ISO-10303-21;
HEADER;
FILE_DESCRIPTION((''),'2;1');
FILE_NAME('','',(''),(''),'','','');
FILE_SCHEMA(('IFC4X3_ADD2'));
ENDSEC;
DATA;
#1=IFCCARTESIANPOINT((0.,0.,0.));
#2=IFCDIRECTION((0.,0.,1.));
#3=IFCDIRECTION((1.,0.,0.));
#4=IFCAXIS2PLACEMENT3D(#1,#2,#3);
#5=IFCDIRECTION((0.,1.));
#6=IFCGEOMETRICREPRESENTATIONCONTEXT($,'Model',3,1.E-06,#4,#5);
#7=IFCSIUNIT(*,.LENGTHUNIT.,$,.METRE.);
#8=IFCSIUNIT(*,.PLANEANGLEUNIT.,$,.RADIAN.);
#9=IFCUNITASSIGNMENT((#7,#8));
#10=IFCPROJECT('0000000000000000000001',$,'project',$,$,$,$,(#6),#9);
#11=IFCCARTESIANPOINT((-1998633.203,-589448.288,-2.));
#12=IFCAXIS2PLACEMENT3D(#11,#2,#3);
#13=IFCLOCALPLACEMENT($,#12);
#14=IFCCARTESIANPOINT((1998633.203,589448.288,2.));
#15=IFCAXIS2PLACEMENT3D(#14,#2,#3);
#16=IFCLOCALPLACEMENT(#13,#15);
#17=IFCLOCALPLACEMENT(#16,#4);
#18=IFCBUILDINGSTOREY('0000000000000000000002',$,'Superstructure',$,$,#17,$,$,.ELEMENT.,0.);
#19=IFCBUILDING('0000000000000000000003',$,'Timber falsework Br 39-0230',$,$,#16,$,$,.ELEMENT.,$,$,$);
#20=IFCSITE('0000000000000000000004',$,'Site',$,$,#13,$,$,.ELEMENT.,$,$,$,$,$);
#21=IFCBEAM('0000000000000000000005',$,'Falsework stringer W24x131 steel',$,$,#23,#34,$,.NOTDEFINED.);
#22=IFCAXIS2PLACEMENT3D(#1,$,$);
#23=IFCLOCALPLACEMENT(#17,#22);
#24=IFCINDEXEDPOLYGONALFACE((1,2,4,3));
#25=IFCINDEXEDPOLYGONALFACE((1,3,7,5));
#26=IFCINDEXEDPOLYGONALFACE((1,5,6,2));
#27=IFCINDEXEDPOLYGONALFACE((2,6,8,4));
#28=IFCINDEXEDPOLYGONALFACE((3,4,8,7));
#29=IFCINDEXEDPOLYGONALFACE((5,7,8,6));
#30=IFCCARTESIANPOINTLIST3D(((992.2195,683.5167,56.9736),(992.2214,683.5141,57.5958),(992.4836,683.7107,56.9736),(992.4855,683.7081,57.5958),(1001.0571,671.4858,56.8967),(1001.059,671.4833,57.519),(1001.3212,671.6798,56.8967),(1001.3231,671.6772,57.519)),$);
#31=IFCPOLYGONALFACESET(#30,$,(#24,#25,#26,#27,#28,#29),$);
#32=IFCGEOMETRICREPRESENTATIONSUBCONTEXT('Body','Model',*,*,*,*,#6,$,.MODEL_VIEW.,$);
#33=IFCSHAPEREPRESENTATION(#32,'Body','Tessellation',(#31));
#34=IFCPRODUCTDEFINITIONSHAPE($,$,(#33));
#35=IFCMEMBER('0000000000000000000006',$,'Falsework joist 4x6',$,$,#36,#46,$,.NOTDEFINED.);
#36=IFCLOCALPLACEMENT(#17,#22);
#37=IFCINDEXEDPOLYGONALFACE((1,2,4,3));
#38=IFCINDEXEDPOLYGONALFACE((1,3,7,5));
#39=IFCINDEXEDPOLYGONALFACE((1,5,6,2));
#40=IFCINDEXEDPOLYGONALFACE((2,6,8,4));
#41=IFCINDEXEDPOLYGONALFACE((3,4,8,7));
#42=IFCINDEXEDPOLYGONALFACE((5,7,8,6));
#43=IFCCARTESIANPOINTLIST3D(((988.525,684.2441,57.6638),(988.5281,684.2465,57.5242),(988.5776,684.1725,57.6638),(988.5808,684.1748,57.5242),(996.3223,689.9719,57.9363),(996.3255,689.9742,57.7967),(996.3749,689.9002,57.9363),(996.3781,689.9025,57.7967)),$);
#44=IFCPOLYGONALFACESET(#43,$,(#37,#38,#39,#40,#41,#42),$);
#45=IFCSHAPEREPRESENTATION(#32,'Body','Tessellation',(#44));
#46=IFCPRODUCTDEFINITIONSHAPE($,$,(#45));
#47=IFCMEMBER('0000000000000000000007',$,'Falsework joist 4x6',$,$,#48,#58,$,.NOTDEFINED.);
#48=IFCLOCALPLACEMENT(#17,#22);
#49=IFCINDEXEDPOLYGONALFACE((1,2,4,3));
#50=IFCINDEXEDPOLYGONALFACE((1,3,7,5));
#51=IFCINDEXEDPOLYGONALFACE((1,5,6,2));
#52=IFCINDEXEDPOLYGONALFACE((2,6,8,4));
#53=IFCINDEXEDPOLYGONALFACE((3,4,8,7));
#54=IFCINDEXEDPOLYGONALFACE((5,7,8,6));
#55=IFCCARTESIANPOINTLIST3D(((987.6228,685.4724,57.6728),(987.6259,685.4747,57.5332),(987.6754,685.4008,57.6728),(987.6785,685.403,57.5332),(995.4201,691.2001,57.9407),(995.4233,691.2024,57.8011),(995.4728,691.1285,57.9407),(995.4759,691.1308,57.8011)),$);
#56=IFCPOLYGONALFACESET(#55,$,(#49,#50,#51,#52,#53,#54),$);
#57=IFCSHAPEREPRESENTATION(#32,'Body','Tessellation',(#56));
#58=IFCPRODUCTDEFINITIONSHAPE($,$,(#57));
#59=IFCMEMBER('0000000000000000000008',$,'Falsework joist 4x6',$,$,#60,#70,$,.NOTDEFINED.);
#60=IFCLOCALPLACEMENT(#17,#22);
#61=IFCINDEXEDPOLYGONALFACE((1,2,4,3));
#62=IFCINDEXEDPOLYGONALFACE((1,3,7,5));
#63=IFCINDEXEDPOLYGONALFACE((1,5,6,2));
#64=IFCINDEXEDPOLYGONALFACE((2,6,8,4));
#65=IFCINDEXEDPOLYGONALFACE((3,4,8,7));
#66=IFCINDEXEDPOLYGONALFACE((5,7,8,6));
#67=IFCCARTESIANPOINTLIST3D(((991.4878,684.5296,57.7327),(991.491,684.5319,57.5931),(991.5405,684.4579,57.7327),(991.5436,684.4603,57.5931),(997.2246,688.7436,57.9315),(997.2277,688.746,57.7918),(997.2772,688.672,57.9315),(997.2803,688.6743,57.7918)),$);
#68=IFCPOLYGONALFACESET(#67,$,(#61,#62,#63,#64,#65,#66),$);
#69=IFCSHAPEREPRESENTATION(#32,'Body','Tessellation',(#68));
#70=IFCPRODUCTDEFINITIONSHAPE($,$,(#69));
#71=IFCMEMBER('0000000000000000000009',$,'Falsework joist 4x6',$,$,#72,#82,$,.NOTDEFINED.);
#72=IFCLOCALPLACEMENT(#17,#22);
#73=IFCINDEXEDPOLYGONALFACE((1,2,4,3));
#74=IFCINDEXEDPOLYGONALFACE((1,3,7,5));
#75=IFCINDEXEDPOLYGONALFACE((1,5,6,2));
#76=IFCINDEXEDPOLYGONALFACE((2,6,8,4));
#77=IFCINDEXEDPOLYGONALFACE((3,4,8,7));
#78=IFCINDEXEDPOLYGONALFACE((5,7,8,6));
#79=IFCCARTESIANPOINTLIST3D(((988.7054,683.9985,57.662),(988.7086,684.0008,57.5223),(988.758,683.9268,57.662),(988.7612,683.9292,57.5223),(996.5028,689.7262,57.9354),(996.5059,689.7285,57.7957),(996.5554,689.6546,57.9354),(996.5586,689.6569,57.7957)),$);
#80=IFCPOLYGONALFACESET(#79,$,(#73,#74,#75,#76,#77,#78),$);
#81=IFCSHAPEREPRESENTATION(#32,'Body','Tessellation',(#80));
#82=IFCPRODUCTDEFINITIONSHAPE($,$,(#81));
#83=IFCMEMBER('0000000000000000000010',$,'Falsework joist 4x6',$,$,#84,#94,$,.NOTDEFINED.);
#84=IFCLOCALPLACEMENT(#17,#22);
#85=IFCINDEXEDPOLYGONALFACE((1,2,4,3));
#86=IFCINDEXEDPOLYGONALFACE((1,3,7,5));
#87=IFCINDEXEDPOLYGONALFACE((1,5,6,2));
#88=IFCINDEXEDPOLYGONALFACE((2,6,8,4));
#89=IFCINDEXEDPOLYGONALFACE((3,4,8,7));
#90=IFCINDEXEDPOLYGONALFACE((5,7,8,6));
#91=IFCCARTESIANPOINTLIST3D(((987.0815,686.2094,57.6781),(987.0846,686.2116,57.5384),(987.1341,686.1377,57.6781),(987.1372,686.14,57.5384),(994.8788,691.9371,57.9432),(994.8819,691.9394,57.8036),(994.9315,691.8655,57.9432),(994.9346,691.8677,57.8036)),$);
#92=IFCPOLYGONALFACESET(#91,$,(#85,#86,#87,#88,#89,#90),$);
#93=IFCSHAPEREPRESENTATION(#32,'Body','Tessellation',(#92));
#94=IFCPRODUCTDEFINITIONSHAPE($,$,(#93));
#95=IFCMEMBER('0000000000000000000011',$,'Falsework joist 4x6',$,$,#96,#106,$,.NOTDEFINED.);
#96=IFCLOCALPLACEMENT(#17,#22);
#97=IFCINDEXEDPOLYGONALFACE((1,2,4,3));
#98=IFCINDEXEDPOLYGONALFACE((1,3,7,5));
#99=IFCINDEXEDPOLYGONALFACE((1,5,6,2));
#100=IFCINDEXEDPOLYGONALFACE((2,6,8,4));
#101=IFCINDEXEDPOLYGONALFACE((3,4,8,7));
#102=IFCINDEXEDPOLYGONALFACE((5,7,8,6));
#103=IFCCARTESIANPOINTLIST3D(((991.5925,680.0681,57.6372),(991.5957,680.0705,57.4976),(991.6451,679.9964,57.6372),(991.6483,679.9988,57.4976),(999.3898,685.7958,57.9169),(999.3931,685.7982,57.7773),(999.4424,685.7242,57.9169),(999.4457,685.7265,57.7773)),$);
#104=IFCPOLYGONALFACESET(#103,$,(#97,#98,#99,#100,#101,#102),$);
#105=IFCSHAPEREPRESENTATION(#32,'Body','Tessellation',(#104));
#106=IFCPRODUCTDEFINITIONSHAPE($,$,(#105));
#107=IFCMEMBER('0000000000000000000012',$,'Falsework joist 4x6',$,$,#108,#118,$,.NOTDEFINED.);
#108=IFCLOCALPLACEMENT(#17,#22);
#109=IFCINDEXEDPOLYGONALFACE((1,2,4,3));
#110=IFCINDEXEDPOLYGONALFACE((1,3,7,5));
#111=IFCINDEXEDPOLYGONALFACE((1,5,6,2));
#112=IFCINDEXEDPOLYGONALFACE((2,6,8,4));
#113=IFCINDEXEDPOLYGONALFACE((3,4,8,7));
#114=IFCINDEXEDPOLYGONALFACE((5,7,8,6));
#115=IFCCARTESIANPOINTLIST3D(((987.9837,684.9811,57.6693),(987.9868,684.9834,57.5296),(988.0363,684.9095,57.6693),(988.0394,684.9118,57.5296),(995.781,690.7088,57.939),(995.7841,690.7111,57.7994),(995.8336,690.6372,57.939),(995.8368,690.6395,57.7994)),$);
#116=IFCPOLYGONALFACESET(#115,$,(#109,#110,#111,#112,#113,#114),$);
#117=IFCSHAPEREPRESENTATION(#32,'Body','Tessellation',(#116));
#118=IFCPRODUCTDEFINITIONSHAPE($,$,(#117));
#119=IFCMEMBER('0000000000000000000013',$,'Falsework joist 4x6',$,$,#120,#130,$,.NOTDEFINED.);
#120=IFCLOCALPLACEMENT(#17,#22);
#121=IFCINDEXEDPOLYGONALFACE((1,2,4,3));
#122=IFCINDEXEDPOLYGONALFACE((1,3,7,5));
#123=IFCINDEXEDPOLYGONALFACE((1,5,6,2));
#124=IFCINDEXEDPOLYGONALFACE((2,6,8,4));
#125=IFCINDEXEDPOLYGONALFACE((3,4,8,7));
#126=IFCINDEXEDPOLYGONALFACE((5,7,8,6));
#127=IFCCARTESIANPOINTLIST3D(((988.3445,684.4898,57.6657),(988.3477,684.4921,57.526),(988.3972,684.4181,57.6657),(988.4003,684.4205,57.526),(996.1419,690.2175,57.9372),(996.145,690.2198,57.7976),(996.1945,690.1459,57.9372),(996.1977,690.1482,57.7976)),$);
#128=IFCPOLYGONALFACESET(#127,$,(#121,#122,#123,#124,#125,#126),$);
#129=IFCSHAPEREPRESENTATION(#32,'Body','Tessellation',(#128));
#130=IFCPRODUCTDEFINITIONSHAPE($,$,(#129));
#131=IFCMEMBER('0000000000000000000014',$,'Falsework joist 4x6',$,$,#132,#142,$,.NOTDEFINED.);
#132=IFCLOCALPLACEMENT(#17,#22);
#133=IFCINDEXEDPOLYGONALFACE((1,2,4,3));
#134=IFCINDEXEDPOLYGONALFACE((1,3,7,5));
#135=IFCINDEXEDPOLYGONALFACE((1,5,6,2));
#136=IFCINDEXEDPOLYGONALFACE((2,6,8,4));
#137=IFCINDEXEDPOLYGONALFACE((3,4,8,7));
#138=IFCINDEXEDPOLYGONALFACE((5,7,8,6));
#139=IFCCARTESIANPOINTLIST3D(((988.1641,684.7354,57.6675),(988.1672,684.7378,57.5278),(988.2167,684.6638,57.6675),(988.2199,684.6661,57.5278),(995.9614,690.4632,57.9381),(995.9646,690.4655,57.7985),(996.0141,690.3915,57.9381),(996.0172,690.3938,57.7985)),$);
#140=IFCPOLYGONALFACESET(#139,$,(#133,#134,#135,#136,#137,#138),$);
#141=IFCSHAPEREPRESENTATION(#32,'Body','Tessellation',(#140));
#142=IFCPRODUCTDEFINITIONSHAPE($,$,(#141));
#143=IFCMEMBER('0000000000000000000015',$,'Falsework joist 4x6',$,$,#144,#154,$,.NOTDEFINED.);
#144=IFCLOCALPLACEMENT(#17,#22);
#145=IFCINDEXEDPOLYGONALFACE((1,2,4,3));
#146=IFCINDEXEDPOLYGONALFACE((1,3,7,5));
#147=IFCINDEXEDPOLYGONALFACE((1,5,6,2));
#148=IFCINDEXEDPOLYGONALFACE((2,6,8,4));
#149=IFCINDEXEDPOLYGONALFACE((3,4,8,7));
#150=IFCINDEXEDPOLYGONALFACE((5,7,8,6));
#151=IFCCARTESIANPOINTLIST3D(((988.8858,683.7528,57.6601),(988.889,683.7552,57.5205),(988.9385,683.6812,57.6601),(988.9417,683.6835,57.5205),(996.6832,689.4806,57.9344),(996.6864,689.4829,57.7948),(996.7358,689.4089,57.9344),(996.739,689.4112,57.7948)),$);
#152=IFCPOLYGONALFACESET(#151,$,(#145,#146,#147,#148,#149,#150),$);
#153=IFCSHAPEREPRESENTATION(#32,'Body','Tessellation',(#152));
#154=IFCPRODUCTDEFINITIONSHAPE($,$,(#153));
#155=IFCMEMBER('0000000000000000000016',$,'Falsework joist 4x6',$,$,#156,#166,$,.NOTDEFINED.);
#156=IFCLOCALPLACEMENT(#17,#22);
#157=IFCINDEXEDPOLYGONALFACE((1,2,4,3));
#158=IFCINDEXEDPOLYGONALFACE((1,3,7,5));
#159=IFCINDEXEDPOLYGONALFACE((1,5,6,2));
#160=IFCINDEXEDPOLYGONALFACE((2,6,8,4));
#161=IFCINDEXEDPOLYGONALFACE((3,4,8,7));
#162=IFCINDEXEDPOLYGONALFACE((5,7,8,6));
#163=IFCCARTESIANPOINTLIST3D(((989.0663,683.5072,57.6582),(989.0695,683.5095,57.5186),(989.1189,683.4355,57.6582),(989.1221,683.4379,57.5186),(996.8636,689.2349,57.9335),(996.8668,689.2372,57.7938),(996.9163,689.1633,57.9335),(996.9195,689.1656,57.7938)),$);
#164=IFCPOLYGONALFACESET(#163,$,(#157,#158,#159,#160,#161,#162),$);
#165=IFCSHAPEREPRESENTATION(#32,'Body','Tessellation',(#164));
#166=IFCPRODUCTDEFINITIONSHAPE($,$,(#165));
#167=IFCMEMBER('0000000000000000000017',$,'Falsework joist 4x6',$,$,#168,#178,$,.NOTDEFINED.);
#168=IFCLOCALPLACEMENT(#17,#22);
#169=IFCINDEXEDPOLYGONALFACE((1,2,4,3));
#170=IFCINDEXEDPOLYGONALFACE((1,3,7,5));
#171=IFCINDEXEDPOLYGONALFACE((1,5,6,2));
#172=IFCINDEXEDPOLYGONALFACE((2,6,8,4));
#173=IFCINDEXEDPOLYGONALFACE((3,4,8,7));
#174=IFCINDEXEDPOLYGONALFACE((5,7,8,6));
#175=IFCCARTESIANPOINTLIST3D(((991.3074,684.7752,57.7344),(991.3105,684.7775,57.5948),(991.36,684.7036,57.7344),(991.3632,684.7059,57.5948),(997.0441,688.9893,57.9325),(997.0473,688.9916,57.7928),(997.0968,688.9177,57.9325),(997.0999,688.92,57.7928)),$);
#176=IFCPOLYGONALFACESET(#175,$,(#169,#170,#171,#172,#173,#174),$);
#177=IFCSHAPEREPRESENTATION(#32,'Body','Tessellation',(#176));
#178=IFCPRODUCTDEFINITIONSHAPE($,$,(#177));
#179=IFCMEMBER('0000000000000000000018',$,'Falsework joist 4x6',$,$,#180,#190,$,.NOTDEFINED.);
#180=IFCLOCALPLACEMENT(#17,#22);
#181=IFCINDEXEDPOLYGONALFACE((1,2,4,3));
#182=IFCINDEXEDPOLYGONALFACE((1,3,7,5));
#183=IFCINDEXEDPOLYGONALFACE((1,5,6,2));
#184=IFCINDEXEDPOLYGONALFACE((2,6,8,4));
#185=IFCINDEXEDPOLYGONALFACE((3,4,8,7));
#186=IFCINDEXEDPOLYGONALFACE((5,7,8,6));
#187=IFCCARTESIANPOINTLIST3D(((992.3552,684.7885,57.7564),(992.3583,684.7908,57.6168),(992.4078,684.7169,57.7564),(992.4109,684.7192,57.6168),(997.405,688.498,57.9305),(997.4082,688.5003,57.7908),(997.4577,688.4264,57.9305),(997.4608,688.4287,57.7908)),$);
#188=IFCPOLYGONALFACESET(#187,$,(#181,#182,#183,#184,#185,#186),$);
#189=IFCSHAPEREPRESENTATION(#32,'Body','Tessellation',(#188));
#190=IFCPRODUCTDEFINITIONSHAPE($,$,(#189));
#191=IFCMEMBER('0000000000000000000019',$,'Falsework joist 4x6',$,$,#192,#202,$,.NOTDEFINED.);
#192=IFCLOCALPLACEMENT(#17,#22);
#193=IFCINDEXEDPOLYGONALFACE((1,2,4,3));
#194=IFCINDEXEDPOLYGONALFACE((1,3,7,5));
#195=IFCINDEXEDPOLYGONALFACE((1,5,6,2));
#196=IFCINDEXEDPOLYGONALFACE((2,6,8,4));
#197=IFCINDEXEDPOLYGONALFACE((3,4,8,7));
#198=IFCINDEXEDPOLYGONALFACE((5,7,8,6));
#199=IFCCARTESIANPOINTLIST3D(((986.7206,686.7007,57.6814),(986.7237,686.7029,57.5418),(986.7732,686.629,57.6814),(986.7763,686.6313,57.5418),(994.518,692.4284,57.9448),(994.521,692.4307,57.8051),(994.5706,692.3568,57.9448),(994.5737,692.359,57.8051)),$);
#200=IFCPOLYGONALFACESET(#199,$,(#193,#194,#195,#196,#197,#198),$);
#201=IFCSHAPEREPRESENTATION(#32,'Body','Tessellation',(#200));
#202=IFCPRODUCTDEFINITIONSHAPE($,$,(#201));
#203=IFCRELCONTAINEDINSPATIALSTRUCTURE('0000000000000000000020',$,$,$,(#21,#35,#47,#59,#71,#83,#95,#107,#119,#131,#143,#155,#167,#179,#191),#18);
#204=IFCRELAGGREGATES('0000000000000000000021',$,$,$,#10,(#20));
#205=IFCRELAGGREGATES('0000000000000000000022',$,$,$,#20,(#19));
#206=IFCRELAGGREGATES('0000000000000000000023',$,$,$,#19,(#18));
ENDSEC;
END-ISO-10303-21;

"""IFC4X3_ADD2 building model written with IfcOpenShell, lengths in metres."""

from ifc_helpers import new_model, si_unit, direction, frame, frame_2d, origin, origin_with_axes, place, context, subcontext, project, spatial, rectangle, extrude, element, save


model = new_model("IFC4X3_ADD2")

# Units and contexts
model_context = context("Model", 3, precision=1e-06, world=origin_with_axes(), true_north=direction((0.0, 1.0)))
body_context = subcontext(model_context, "Body", "Model", "MODEL_VIEW")
ifc_project = project(units=[si_unit("LENGTHUNIT", "METRE"), si_unit("PLANEANGLEUNIT", "RADIAN")], contexts=[model_context])

# Site, building, storey
site_placement = place(None, frame((-1998633.203, -589448.288, -2.0), z_axis=(0.0, 0.0, 1.0), x_axis=(1.0, 0.0, 0.0)))
site = spatial("IfcSite", under=ifc_project, at=site_placement, Name="Site", CompositionType="ELEMENT")
building_placement = place(site_placement, frame((1998633.203, 589448.288, 2.0), z_axis=(0.0, 0.0, 1.0), x_axis=(1.0, 0.0, 0.0)))
building = spatial("IfcBuilding", under=site, at=building_placement, Name="Timber falsework Br 39-0230", CompositionType="ELEMENT")
storey_placement = place(building_placement, origin_with_axes())
storey = spatial("IfcBuildingStorey", under=building, at=storey_placement, Name="Superstructure", CompositionType="ELEMENT", Elevation=0.0)

# Beam
beam_placement = place(storey_placement, frame((992.3516, 683.6137, 56.9736), z_axis=(0.592005, -0.805918, -0.005147), x_axis=(0.805928, 0.592013, 0.0)))
element("IfcBeam", 1, at=beam_placement, inside=storey, Name="Falsework stringer W24x131 steel", PredefinedType="NOTDEFINED", context=body_context, shape_type="SweptSolid", body=[
    extrude(rectangle(XDim=0.3277, YDim=0.6223, at=frame_2d((0.0, 0.3111))), origin(), (0.0, 0.0, 1.0), 14.9282),
])

# Members
member_1_placement = place(storey_placement, frame((988.5544, 684.2106, 57.5242), z_axis=(0.805609, 0.591779, 0.028152), x_axis=(-0.592013, 0.805928, 0.0)))
element("IfcMember", 2, at=member_1_placement, inside=storey, Name="Falsework joist 4x6", PredefinedType="NOTDEFINED", context=body_context, shape_type="SweptSolid", body=[
    extrude(rectangle(XDim=0.0889, YDim=0.1397, at=frame_2d((0.0, 0.0698))), origin(), (0.0, 0.0, 1.0), 9.6788),
])
member_2_placement = place(storey_placement, frame((987.6522, 685.4389, 57.5332), z_axis=(0.80562, 0.591786, 0.027679), x_axis=(-0.592013, 0.805928, 0.0)))
element("IfcMember", 3, at=member_2_placement, inside=storey, Name="Falsework joist 4x6", PredefinedType="NOTDEFINED", context=body_context, shape_type="SweptSolid", body=[
    extrude(rectangle(XDim=0.0889, YDim=0.1397, at=frame_2d((0.0, 0.0698))), origin(), (0.0, 0.0, 1.0), 9.6787),
])
member_3_placement = place(storey_placement, frame((991.5173, 684.4961, 57.5931), z_axis=(0.805614, 0.591783, 0.027911), x_axis=(-0.592013, 0.805928, 0.0)))
element("IfcMember", 4, at=member_3_placement, inside=storey, Name="Falsework joist 4x6", PredefinedType="NOTDEFINED", context=body_context, shape_type="SweptSolid", body=[
    extrude(rectangle(XDim=0.0889, YDim=0.1397, at=frame_2d((0.0, 0.0698))), origin(), (0.0, 0.0, 1.0), 7.121),
])
member_4_placement = place(storey_placement, frame((988.7349, 683.965, 57.5223), z_axis=(0.805607, 0.591777, 0.028246), x_axis=(-0.592013, 0.805928, 0.0)))
element("IfcMember", 5, at=member_4_placement, inside=storey, Name="Falsework joist 4x6", PredefinedType="NOTDEFINED", context=body_context, shape_type="SweptSolid", body=[
    extrude(rectangle(XDim=0.0889, YDim=0.1397, at=frame_2d((0.0, 0.0698))), origin(), (0.0, 0.0, 1.0), 9.6789),
])
member_5_placement = place(storey_placement, frame((987.1109, 686.1758, 57.5384), z_axis=(0.805626, 0.591791, 0.027395), x_axis=(-0.592013, 0.805928, 0.0)))
element("IfcMember", 6, at=member_5_placement, inside=storey, Name="Falsework joist 4x6", PredefinedType="NOTDEFINED", context=body_context, shape_type="SweptSolid", body=[
    extrude(rectangle(XDim=0.0889, YDim=0.1397, at=frame_2d((0.0, 0.0698))), origin(), (0.0, 0.0, 1.0), 9.6786),
])
member_6_placement = place(storey_placement, frame((991.622, 680.0346, 57.4976), z_axis=(0.805592, 0.591766, 0.028902), x_axis=(-0.592013, 0.805928, 0.0)))
element("IfcMember", 7, at=member_6_placement, inside=storey, Name="Falsework joist 4x6", PredefinedType="NOTDEFINED", context=body_context, shape_type="SweptSolid", body=[
    extrude(rectangle(XDim=0.0889, YDim=0.1397, at=frame_2d((0.0, 0.0698))), origin(), (0.0, 0.0, 1.0), 9.679),
])
member_7_placement = place(storey_placement, frame((988.0131, 684.9476, 57.5296), z_axis=(0.805615, 0.591783, 0.027868), x_axis=(-0.592013, 0.805928, 0.0)))
element("IfcMember", 8, at=member_7_placement, inside=storey, Name="Falsework joist 4x6", PredefinedType="NOTDEFINED", context=body_context, shape_type="SweptSolid", body=[
    extrude(rectangle(XDim=0.0889, YDim=0.1397, at=frame_2d((0.0, 0.0698))), origin(), (0.0, 0.0, 1.0), 9.6788),
])
member_8_placement = place(storey_placement, frame((988.374, 684.4563, 57.526), z_axis=(0.805611, 0.59178, 0.028057), x_axis=(-0.592013, 0.805928, 0.0)))
element("IfcMember", 9, at=member_8_placement, inside=storey, Name="Falsework joist 4x6", PredefinedType="NOTDEFINED", context=body_context, shape_type="SweptSolid", body=[
    extrude(rectangle(XDim=0.0889, YDim=0.1397, at=frame_2d((0.0, 0.0698))), origin(), (0.0, 0.0, 1.0), 9.6788),
])
member_9_placement = place(storey_placement, frame((988.1936, 684.7019, 57.5278), z_axis=(0.805613, 0.591782, 0.027963), x_axis=(-0.592013, 0.805928, 0.0)))
element("IfcMember", 10, at=member_9_placement, inside=storey, Name="Falsework joist 4x6", PredefinedType="NOTDEFINED", context=body_context, shape_type="SweptSolid", body=[
    extrude(rectangle(XDim=0.0889, YDim=0.1397, at=frame_2d((0.0, 0.0698))), origin(), (0.0, 0.0, 1.0), 9.6788),
])
member_10_placement = place(storey_placement, frame((988.9153, 683.7193, 57.5205), z_axis=(0.805605, 0.591775, 0.028341), x_axis=(-0.592013, 0.805928, 0.0)))
element("IfcMember", 11, at=member_10_placement, inside=storey, Name="Falsework joist 4x6", PredefinedType="NOTDEFINED", context=body_context, shape_type="SweptSolid", body=[
    extrude(rectangle(XDim=0.0889, YDim=0.1397, at=frame_2d((0.0, 0.0698))), origin(), (0.0, 0.0, 1.0), 9.6789),
])
member_11_placement = place(storey_placement, frame((989.0958, 683.4737, 57.5186), z_axis=(0.805602, 0.591774, 0.028436), x_axis=(-0.592013, 0.805928, 0.0)))
element("IfcMember", 12, at=member_11_placement, inside=storey, Name="Falsework joist 4x6", PredefinedType="NOTDEFINED", context=body_context, shape_type="SweptSolid", body=[
    extrude(rectangle(XDim=0.0889, YDim=0.1397, at=frame_2d((0.0, 0.0698))), origin(), (0.0, 0.0, 1.0), 9.6789),
])
member_12_placement = place(storey_placement, frame((991.3368, 684.7417, 57.5948), z_axis=(0.805616, 0.591784, 0.027816), x_axis=(-0.592013, 0.805928, 0.0)))
element("IfcMember", 13, at=member_12_placement, inside=storey, Name="Falsework joist 4x6", PredefinedType="NOTDEFINED", context=body_context, shape_type="SweptSolid", body=[
    extrude(rectangle(XDim=0.0889, YDim=0.1397, at=frame_2d((0.0, 0.0698))), origin(), (0.0, 0.0, 1.0), 7.1209),
])
member_13_placement = place(storey_placement, frame((992.3846, 684.755, 57.6168), z_axis=(0.805618, 0.591785, 0.027768), x_axis=(-0.592013, 0.805928, 0.0)))
element("IfcMember", 14, at=member_13_placement, inside=storey, Name="Falsework joist 4x6", PredefinedType="NOTDEFINED", context=body_context, shape_type="SweptSolid", body=[
    extrude(rectangle(XDim=0.0889, YDim=0.1397, at=frame_2d((0.0, 0.0698))), origin(), (0.0, 0.0, 1.0), 6.2683),
])
member_14_placement = place(storey_placement, frame((986.75, 686.6671, 57.5418), z_axis=(0.80563, 0.591794, 0.027206), x_axis=(-0.592013, 0.805928, 0.0)))
element("IfcMember", 15, at=member_14_placement, inside=storey, Name="Falsework joist 4x6", PredefinedType="NOTDEFINED", context=body_context, shape_type="SweptSolid", body=[
    extrude(rectangle(XDim=0.0889, YDim=0.1397, at=frame_2d((0.0, 0.0698))), origin(), (0.0, 0.0, 1.0), 9.6786),
])

save(model, "model.ifc")
